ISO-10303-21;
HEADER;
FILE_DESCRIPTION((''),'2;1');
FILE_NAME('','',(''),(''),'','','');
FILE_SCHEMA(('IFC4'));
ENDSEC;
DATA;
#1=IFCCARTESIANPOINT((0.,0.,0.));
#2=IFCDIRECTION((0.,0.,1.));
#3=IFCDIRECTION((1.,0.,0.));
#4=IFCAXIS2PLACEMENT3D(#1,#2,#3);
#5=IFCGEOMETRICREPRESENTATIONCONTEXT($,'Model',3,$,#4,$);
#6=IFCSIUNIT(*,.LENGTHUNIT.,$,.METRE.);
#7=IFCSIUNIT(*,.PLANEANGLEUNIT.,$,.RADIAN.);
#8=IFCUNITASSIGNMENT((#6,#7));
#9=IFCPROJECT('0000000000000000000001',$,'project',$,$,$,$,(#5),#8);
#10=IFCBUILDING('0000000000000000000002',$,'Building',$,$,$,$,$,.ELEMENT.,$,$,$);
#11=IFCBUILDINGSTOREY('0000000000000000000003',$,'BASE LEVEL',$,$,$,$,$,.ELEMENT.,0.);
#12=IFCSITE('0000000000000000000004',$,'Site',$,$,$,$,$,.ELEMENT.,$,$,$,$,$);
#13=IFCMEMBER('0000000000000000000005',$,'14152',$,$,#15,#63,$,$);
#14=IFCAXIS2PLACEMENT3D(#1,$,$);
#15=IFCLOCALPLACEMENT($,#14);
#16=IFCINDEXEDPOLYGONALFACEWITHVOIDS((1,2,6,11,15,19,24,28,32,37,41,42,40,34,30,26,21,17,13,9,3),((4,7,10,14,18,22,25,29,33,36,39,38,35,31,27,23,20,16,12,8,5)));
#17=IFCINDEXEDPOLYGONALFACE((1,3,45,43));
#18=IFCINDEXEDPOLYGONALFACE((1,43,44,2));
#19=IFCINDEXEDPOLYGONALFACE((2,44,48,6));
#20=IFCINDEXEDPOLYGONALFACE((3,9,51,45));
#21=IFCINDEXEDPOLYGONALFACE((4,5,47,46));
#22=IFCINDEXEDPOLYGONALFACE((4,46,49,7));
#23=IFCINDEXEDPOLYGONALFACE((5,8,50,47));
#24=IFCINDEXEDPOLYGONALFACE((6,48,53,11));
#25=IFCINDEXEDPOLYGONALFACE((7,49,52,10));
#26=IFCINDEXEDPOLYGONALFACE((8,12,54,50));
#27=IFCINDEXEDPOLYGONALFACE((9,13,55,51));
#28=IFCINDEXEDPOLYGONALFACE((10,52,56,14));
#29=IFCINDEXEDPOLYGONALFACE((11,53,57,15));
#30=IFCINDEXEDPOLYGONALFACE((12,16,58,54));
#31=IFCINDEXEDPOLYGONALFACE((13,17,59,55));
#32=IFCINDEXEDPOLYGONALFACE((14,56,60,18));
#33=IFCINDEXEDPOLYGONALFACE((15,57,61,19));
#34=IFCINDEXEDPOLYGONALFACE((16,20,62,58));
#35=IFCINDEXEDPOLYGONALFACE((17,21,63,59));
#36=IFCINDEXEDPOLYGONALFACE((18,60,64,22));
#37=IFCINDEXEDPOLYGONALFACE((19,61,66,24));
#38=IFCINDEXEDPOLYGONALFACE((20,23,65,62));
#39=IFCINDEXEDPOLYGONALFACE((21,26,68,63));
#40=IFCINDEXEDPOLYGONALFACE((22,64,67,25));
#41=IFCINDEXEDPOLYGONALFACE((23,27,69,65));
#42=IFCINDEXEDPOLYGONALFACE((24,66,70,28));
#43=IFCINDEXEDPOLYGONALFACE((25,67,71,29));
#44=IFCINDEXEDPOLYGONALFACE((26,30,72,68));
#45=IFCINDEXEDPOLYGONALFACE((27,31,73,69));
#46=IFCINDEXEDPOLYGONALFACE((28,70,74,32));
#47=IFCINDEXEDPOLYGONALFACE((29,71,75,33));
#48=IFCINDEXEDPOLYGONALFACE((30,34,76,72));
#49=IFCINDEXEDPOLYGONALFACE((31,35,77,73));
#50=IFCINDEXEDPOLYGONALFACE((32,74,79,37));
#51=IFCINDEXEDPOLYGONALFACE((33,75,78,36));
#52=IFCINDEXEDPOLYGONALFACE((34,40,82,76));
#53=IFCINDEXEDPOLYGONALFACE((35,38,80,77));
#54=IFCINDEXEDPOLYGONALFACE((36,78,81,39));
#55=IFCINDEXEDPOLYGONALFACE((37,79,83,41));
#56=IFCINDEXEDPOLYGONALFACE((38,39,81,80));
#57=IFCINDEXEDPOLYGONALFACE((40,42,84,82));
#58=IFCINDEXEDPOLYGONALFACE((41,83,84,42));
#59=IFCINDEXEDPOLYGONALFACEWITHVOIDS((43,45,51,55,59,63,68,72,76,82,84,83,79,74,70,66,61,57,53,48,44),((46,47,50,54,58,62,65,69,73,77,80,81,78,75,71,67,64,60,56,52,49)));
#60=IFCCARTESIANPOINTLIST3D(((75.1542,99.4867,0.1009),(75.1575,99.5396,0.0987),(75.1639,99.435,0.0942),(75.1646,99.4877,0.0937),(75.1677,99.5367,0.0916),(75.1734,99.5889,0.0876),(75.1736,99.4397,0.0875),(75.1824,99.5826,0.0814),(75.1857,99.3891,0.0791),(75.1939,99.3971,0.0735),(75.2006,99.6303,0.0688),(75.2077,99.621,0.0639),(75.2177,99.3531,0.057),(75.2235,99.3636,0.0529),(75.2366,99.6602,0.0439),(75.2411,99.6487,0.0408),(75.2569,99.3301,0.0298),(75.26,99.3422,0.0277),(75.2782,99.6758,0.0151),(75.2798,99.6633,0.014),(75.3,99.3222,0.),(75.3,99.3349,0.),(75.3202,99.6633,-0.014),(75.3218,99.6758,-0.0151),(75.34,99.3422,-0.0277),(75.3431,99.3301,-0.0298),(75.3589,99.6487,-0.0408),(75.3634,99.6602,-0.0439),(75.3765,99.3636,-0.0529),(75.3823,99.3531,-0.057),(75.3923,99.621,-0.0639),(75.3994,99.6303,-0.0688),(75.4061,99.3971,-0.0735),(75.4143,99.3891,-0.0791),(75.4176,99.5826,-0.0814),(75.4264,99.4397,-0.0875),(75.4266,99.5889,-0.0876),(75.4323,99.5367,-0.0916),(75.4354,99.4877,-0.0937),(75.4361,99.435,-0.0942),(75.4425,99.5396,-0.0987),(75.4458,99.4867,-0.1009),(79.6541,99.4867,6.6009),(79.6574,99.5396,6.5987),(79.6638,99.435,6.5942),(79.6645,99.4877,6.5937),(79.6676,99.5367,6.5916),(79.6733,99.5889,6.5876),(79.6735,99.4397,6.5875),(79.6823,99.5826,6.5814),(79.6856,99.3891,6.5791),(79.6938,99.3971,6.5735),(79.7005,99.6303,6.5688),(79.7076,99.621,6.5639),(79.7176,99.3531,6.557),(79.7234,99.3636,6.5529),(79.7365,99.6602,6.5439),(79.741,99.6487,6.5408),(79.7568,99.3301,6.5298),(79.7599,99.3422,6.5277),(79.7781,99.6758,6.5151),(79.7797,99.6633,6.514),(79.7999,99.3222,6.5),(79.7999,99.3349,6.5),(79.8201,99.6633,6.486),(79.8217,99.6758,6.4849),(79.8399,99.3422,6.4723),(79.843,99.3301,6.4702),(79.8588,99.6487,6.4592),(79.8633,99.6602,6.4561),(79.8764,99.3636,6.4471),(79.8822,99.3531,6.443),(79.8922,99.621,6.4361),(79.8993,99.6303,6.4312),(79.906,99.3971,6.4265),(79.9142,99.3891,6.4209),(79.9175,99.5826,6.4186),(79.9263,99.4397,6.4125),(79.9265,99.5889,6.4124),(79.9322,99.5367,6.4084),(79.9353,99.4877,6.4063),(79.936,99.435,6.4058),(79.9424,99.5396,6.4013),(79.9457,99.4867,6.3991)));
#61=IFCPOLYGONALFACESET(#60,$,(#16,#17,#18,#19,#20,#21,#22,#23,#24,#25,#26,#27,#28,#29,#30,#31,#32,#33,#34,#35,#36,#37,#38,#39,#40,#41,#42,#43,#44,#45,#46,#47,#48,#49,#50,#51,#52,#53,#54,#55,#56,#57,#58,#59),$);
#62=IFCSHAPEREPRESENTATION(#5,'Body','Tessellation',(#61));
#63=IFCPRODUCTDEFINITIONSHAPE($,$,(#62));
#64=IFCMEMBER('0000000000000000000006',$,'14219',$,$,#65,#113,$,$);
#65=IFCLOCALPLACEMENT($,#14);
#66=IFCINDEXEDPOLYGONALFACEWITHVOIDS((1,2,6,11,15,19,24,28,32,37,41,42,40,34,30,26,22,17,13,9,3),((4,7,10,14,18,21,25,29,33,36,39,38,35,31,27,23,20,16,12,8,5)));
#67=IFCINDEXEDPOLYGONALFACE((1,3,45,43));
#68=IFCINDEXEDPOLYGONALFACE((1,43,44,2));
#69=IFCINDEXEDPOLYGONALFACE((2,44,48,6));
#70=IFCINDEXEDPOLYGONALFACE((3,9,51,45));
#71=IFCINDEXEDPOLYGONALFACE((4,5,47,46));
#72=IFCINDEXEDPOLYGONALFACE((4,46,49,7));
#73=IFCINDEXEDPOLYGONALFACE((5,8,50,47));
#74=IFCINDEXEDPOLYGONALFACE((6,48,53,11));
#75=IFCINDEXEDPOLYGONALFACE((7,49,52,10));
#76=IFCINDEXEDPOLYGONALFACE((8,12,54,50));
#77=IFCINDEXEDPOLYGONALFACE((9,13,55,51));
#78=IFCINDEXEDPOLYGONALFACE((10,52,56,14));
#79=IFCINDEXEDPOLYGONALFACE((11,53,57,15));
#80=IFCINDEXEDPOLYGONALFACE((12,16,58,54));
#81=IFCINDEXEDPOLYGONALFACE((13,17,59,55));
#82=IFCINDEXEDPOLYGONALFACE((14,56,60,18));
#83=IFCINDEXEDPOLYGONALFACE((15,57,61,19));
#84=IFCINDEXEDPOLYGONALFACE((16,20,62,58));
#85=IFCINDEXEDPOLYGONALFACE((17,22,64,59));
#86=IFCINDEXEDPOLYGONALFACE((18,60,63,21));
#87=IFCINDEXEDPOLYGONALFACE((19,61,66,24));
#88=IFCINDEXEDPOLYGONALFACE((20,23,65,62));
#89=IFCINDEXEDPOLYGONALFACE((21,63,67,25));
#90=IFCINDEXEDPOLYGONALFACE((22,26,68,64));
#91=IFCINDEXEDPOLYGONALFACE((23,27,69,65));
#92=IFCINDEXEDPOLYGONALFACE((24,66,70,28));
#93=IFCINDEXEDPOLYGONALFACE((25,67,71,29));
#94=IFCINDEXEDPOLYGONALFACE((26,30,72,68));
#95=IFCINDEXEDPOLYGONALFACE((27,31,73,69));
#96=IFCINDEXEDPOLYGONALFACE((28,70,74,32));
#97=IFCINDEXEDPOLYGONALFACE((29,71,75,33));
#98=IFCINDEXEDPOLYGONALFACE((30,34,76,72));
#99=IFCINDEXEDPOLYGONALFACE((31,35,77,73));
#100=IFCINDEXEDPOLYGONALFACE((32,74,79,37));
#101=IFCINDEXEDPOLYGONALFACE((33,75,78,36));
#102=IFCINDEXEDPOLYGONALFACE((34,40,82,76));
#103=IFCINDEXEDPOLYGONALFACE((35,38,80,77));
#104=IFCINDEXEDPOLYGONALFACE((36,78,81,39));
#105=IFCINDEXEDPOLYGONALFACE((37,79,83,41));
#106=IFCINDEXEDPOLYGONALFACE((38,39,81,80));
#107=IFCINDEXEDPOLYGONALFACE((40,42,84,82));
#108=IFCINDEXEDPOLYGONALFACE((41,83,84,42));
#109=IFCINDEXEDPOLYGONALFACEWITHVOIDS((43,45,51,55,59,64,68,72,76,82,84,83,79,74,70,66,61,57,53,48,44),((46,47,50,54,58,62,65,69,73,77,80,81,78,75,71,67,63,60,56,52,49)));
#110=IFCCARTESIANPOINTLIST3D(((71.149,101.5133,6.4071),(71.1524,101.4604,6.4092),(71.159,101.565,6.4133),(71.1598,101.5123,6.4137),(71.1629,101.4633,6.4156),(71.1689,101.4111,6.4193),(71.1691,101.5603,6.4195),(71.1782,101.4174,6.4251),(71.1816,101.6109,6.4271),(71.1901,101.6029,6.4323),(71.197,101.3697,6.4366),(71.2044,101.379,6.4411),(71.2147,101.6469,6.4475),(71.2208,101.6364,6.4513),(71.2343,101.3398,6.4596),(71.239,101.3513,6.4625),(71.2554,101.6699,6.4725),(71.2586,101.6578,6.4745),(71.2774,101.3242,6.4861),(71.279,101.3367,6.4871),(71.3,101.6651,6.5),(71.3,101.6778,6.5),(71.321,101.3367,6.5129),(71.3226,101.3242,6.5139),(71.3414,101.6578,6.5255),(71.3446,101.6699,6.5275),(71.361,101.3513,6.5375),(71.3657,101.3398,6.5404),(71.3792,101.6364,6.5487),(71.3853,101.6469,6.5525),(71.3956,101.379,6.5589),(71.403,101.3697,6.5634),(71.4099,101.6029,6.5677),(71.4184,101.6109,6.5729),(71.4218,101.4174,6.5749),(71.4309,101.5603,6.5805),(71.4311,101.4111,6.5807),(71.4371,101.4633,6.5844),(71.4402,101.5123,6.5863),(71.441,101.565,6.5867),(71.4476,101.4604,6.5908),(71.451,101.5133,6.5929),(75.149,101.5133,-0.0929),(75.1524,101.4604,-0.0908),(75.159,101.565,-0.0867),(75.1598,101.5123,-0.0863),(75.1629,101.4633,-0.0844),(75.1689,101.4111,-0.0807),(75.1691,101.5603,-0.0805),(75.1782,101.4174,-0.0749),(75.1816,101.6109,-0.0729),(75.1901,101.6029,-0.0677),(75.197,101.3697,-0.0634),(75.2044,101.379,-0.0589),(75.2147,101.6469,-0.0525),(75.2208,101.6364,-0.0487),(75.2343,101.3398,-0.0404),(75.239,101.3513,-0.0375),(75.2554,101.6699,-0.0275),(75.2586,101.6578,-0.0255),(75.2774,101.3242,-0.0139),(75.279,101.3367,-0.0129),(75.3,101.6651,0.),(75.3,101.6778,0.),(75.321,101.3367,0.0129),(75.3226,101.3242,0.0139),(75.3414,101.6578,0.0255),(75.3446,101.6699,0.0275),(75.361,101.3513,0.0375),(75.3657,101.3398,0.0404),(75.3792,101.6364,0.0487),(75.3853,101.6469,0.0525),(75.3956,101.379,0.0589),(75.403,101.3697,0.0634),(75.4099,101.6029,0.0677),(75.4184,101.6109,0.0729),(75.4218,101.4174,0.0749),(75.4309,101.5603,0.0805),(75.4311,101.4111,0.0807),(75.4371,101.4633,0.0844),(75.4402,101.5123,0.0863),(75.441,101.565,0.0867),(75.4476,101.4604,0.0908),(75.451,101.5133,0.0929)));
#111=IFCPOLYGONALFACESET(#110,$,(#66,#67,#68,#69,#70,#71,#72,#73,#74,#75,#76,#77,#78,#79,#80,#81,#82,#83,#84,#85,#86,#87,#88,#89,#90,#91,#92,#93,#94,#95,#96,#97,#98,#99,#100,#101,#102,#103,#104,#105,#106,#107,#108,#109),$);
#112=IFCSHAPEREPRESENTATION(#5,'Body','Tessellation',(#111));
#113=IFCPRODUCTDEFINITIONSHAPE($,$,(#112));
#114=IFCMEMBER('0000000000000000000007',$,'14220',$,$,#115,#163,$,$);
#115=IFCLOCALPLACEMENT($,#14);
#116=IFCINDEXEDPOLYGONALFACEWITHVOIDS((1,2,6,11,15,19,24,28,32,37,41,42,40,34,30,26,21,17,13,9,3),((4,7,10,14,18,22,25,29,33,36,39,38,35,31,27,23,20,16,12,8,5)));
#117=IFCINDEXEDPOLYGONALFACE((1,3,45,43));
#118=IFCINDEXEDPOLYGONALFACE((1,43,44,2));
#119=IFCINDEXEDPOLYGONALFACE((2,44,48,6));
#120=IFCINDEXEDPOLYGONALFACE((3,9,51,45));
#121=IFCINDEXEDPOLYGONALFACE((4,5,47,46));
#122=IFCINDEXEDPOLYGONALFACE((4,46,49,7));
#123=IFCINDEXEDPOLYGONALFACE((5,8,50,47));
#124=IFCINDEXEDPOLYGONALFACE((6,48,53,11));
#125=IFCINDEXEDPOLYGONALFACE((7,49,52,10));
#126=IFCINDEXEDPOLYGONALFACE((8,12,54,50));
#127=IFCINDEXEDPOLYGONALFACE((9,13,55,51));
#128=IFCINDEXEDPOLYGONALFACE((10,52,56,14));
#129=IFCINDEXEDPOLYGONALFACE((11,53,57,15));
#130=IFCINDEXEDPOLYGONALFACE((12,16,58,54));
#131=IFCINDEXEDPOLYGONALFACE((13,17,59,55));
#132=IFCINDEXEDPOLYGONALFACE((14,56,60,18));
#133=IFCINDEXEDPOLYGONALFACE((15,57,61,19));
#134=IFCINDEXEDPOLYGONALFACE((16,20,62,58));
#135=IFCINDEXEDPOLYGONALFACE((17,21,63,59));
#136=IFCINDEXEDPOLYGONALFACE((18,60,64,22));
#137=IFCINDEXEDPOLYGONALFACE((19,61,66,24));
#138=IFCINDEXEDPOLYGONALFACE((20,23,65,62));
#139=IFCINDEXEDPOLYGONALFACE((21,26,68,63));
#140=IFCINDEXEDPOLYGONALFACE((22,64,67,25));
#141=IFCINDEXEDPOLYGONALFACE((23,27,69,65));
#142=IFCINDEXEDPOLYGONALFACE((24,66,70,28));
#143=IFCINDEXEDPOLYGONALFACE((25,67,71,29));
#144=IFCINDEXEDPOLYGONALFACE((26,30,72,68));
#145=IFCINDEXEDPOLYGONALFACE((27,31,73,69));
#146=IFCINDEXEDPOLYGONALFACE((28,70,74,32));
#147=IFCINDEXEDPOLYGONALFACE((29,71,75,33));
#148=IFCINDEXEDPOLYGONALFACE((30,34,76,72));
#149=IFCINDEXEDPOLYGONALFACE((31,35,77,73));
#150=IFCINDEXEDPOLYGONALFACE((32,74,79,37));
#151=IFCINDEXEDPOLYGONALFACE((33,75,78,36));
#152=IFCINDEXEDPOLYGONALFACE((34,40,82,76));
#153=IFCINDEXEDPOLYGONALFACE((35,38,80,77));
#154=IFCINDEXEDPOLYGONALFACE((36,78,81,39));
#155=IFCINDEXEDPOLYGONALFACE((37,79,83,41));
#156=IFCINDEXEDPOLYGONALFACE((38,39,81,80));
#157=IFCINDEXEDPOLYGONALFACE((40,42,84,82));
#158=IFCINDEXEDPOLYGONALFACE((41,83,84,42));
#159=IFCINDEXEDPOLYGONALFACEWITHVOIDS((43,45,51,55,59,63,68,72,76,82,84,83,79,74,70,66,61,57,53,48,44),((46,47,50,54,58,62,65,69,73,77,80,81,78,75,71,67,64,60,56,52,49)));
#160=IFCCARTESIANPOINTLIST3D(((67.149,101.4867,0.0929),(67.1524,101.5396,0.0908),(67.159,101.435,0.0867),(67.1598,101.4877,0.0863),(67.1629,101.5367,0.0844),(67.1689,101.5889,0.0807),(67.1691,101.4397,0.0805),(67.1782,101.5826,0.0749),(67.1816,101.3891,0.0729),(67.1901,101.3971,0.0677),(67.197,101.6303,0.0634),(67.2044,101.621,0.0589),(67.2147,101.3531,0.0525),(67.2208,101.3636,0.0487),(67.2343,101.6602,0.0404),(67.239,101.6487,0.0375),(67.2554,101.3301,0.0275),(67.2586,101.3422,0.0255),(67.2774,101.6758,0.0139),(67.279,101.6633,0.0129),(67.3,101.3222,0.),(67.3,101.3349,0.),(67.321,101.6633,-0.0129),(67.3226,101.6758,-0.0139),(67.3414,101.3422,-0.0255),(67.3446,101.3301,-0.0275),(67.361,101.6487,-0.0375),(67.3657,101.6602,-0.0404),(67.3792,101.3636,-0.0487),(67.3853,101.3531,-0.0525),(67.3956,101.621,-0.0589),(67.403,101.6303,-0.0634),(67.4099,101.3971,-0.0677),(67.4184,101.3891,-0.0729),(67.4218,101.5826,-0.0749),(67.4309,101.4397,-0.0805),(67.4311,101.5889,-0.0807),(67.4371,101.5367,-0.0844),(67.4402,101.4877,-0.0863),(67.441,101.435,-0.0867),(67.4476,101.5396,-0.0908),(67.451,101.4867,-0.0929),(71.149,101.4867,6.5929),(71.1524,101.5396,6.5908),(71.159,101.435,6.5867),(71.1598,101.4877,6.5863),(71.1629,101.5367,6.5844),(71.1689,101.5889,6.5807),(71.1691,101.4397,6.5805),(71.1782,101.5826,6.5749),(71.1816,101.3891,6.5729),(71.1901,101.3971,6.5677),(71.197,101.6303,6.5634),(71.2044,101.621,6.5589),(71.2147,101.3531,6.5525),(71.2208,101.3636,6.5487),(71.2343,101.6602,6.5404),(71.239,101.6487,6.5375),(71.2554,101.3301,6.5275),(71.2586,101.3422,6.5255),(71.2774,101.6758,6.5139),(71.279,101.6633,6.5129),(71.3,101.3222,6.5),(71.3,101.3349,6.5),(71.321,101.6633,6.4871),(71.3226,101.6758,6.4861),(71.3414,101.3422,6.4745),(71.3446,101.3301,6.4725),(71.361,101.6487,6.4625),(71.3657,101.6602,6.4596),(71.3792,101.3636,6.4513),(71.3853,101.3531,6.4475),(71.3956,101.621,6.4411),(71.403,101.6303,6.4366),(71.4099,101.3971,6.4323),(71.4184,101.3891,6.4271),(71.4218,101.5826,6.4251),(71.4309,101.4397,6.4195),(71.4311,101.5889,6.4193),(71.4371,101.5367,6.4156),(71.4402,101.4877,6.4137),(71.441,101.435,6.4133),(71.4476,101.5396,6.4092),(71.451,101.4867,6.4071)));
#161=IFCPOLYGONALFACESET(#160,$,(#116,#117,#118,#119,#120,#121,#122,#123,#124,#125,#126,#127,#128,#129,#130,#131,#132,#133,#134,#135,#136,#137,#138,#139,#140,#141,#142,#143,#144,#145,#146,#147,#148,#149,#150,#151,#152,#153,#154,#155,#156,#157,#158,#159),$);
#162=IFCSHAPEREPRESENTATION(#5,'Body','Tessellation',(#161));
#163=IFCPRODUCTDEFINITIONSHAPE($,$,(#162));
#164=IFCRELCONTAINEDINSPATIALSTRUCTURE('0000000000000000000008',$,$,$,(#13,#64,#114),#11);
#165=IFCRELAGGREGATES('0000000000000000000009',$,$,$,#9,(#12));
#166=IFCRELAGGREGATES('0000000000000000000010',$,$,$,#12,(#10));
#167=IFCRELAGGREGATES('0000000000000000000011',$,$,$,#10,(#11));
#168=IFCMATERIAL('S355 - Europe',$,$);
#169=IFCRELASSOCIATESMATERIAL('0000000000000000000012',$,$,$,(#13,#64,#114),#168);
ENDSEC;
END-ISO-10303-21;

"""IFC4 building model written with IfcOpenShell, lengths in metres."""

from ifc_helpers import new_model, si_unit, frame, origin_with_axes, origin_2d_with_axis, place, context, project, spatial, hollow_circle, extrude, material, material_profile, profile_set, profile_usage, element, save


model = new_model("IFC4")

# Units and contexts
model_context = context("Model", 3, world=origin_with_axes())
ifc_project = project(units=[si_unit("LENGTHUNIT", "METRE"), si_unit("PLANEANGLEUNIT", "RADIAN")], contexts=[model_context])

# Site, building, storey
site = spatial("IfcSite", under=ifc_project, Name="Site", CompositionType="ELEMENT")
building = spatial("IfcBuilding", under=site, Name="Building", CompositionType="ELEMENT")
storey = spatial("IfcBuildingStorey", under=building, Name="BASE LEVEL", CompositionType="ELEMENT", Elevation=0.0)

# Shared definitions
ifc_material = material(Name="S355 - Europe")

# Members
ifc_material_profile_1 = material_profile(ifc_material, hollow_circle(Radius=0.1778, WallThickness=0.0127, at=origin_2d_with_axis()))
ifc_profile_set_1 = profile_set([ifc_material_profile_1])
ifc_profile_usage_1 = profile_usage(ifc_profile_set_1, cardinal=10)
member_1_placement = place(None, frame((79.7999, 99.5, 6.5), z_axis=(-0.569201, 0.0, -0.822198), x_axis=(0.0, -1.0, 0.0)))
element("IfcMember", 1, at=member_1_placement, inside=storey, material=ifc_profile_usage_1, Name="14152", context=model_context, shape_type="SweptSolid", body=[
    extrude(hollow_circle(Radius=0.1778, WallThickness=0.0127, at=origin_2d_with_axis()), origin_with_axes(), (0.0, 0.0, 1.0), 7.9056),
])
ifc_material_profile_2 = material_profile(ifc_material, hollow_circle(Radius=0.1778, WallThickness=0.0127, at=origin_2d_with_axis()))
ifc_profile_set_2 = profile_set([ifc_material_profile_2])
ifc_profile_usage_2 = profile_usage(ifc_profile_set_2, cardinal=10)
member_2_placement = place(None, frame((71.3, 101.5, 6.5), z_axis=(0.524097, 0.0, -0.851658), x_axis=(0.0, 1.0, 0.0)))
element("IfcMember", 2, at=member_2_placement, inside=storey, material=ifc_profile_usage_2, Name="14219", context=model_context, shape_type="SweptSolid", body=[
    extrude(hollow_circle(Radius=0.1778, WallThickness=0.0127, at=origin_2d_with_axis()), origin_with_axes(), (0.0, 0.0, 1.0), 7.6322),
])
ifc_material_profile_3 = material_profile(ifc_material, hollow_circle(Radius=0.1778, WallThickness=0.0127, at=origin_2d_with_axis()))
ifc_profile_set_3 = profile_set([ifc_material_profile_3])
ifc_profile_usage_3 = profile_usage(ifc_profile_set_3, cardinal=10)
member_3_placement = place(None, frame((71.3, 101.5, 6.5), z_axis=(-0.524097, 0.0, -0.851658), x_axis=(0.0, -1.0, 0.0)))
element("IfcMember", 3, at=member_3_placement, inside=storey, material=ifc_profile_usage_3, Name="14220", context=model_context, shape_type="SweptSolid", body=[
    extrude(hollow_circle(Radius=0.1778, WallThickness=0.0127, at=origin_2d_with_axis()), origin_with_axes(), (0.0, 0.0, 1.0), 7.6322),
])

save(model, "model.ifc")
